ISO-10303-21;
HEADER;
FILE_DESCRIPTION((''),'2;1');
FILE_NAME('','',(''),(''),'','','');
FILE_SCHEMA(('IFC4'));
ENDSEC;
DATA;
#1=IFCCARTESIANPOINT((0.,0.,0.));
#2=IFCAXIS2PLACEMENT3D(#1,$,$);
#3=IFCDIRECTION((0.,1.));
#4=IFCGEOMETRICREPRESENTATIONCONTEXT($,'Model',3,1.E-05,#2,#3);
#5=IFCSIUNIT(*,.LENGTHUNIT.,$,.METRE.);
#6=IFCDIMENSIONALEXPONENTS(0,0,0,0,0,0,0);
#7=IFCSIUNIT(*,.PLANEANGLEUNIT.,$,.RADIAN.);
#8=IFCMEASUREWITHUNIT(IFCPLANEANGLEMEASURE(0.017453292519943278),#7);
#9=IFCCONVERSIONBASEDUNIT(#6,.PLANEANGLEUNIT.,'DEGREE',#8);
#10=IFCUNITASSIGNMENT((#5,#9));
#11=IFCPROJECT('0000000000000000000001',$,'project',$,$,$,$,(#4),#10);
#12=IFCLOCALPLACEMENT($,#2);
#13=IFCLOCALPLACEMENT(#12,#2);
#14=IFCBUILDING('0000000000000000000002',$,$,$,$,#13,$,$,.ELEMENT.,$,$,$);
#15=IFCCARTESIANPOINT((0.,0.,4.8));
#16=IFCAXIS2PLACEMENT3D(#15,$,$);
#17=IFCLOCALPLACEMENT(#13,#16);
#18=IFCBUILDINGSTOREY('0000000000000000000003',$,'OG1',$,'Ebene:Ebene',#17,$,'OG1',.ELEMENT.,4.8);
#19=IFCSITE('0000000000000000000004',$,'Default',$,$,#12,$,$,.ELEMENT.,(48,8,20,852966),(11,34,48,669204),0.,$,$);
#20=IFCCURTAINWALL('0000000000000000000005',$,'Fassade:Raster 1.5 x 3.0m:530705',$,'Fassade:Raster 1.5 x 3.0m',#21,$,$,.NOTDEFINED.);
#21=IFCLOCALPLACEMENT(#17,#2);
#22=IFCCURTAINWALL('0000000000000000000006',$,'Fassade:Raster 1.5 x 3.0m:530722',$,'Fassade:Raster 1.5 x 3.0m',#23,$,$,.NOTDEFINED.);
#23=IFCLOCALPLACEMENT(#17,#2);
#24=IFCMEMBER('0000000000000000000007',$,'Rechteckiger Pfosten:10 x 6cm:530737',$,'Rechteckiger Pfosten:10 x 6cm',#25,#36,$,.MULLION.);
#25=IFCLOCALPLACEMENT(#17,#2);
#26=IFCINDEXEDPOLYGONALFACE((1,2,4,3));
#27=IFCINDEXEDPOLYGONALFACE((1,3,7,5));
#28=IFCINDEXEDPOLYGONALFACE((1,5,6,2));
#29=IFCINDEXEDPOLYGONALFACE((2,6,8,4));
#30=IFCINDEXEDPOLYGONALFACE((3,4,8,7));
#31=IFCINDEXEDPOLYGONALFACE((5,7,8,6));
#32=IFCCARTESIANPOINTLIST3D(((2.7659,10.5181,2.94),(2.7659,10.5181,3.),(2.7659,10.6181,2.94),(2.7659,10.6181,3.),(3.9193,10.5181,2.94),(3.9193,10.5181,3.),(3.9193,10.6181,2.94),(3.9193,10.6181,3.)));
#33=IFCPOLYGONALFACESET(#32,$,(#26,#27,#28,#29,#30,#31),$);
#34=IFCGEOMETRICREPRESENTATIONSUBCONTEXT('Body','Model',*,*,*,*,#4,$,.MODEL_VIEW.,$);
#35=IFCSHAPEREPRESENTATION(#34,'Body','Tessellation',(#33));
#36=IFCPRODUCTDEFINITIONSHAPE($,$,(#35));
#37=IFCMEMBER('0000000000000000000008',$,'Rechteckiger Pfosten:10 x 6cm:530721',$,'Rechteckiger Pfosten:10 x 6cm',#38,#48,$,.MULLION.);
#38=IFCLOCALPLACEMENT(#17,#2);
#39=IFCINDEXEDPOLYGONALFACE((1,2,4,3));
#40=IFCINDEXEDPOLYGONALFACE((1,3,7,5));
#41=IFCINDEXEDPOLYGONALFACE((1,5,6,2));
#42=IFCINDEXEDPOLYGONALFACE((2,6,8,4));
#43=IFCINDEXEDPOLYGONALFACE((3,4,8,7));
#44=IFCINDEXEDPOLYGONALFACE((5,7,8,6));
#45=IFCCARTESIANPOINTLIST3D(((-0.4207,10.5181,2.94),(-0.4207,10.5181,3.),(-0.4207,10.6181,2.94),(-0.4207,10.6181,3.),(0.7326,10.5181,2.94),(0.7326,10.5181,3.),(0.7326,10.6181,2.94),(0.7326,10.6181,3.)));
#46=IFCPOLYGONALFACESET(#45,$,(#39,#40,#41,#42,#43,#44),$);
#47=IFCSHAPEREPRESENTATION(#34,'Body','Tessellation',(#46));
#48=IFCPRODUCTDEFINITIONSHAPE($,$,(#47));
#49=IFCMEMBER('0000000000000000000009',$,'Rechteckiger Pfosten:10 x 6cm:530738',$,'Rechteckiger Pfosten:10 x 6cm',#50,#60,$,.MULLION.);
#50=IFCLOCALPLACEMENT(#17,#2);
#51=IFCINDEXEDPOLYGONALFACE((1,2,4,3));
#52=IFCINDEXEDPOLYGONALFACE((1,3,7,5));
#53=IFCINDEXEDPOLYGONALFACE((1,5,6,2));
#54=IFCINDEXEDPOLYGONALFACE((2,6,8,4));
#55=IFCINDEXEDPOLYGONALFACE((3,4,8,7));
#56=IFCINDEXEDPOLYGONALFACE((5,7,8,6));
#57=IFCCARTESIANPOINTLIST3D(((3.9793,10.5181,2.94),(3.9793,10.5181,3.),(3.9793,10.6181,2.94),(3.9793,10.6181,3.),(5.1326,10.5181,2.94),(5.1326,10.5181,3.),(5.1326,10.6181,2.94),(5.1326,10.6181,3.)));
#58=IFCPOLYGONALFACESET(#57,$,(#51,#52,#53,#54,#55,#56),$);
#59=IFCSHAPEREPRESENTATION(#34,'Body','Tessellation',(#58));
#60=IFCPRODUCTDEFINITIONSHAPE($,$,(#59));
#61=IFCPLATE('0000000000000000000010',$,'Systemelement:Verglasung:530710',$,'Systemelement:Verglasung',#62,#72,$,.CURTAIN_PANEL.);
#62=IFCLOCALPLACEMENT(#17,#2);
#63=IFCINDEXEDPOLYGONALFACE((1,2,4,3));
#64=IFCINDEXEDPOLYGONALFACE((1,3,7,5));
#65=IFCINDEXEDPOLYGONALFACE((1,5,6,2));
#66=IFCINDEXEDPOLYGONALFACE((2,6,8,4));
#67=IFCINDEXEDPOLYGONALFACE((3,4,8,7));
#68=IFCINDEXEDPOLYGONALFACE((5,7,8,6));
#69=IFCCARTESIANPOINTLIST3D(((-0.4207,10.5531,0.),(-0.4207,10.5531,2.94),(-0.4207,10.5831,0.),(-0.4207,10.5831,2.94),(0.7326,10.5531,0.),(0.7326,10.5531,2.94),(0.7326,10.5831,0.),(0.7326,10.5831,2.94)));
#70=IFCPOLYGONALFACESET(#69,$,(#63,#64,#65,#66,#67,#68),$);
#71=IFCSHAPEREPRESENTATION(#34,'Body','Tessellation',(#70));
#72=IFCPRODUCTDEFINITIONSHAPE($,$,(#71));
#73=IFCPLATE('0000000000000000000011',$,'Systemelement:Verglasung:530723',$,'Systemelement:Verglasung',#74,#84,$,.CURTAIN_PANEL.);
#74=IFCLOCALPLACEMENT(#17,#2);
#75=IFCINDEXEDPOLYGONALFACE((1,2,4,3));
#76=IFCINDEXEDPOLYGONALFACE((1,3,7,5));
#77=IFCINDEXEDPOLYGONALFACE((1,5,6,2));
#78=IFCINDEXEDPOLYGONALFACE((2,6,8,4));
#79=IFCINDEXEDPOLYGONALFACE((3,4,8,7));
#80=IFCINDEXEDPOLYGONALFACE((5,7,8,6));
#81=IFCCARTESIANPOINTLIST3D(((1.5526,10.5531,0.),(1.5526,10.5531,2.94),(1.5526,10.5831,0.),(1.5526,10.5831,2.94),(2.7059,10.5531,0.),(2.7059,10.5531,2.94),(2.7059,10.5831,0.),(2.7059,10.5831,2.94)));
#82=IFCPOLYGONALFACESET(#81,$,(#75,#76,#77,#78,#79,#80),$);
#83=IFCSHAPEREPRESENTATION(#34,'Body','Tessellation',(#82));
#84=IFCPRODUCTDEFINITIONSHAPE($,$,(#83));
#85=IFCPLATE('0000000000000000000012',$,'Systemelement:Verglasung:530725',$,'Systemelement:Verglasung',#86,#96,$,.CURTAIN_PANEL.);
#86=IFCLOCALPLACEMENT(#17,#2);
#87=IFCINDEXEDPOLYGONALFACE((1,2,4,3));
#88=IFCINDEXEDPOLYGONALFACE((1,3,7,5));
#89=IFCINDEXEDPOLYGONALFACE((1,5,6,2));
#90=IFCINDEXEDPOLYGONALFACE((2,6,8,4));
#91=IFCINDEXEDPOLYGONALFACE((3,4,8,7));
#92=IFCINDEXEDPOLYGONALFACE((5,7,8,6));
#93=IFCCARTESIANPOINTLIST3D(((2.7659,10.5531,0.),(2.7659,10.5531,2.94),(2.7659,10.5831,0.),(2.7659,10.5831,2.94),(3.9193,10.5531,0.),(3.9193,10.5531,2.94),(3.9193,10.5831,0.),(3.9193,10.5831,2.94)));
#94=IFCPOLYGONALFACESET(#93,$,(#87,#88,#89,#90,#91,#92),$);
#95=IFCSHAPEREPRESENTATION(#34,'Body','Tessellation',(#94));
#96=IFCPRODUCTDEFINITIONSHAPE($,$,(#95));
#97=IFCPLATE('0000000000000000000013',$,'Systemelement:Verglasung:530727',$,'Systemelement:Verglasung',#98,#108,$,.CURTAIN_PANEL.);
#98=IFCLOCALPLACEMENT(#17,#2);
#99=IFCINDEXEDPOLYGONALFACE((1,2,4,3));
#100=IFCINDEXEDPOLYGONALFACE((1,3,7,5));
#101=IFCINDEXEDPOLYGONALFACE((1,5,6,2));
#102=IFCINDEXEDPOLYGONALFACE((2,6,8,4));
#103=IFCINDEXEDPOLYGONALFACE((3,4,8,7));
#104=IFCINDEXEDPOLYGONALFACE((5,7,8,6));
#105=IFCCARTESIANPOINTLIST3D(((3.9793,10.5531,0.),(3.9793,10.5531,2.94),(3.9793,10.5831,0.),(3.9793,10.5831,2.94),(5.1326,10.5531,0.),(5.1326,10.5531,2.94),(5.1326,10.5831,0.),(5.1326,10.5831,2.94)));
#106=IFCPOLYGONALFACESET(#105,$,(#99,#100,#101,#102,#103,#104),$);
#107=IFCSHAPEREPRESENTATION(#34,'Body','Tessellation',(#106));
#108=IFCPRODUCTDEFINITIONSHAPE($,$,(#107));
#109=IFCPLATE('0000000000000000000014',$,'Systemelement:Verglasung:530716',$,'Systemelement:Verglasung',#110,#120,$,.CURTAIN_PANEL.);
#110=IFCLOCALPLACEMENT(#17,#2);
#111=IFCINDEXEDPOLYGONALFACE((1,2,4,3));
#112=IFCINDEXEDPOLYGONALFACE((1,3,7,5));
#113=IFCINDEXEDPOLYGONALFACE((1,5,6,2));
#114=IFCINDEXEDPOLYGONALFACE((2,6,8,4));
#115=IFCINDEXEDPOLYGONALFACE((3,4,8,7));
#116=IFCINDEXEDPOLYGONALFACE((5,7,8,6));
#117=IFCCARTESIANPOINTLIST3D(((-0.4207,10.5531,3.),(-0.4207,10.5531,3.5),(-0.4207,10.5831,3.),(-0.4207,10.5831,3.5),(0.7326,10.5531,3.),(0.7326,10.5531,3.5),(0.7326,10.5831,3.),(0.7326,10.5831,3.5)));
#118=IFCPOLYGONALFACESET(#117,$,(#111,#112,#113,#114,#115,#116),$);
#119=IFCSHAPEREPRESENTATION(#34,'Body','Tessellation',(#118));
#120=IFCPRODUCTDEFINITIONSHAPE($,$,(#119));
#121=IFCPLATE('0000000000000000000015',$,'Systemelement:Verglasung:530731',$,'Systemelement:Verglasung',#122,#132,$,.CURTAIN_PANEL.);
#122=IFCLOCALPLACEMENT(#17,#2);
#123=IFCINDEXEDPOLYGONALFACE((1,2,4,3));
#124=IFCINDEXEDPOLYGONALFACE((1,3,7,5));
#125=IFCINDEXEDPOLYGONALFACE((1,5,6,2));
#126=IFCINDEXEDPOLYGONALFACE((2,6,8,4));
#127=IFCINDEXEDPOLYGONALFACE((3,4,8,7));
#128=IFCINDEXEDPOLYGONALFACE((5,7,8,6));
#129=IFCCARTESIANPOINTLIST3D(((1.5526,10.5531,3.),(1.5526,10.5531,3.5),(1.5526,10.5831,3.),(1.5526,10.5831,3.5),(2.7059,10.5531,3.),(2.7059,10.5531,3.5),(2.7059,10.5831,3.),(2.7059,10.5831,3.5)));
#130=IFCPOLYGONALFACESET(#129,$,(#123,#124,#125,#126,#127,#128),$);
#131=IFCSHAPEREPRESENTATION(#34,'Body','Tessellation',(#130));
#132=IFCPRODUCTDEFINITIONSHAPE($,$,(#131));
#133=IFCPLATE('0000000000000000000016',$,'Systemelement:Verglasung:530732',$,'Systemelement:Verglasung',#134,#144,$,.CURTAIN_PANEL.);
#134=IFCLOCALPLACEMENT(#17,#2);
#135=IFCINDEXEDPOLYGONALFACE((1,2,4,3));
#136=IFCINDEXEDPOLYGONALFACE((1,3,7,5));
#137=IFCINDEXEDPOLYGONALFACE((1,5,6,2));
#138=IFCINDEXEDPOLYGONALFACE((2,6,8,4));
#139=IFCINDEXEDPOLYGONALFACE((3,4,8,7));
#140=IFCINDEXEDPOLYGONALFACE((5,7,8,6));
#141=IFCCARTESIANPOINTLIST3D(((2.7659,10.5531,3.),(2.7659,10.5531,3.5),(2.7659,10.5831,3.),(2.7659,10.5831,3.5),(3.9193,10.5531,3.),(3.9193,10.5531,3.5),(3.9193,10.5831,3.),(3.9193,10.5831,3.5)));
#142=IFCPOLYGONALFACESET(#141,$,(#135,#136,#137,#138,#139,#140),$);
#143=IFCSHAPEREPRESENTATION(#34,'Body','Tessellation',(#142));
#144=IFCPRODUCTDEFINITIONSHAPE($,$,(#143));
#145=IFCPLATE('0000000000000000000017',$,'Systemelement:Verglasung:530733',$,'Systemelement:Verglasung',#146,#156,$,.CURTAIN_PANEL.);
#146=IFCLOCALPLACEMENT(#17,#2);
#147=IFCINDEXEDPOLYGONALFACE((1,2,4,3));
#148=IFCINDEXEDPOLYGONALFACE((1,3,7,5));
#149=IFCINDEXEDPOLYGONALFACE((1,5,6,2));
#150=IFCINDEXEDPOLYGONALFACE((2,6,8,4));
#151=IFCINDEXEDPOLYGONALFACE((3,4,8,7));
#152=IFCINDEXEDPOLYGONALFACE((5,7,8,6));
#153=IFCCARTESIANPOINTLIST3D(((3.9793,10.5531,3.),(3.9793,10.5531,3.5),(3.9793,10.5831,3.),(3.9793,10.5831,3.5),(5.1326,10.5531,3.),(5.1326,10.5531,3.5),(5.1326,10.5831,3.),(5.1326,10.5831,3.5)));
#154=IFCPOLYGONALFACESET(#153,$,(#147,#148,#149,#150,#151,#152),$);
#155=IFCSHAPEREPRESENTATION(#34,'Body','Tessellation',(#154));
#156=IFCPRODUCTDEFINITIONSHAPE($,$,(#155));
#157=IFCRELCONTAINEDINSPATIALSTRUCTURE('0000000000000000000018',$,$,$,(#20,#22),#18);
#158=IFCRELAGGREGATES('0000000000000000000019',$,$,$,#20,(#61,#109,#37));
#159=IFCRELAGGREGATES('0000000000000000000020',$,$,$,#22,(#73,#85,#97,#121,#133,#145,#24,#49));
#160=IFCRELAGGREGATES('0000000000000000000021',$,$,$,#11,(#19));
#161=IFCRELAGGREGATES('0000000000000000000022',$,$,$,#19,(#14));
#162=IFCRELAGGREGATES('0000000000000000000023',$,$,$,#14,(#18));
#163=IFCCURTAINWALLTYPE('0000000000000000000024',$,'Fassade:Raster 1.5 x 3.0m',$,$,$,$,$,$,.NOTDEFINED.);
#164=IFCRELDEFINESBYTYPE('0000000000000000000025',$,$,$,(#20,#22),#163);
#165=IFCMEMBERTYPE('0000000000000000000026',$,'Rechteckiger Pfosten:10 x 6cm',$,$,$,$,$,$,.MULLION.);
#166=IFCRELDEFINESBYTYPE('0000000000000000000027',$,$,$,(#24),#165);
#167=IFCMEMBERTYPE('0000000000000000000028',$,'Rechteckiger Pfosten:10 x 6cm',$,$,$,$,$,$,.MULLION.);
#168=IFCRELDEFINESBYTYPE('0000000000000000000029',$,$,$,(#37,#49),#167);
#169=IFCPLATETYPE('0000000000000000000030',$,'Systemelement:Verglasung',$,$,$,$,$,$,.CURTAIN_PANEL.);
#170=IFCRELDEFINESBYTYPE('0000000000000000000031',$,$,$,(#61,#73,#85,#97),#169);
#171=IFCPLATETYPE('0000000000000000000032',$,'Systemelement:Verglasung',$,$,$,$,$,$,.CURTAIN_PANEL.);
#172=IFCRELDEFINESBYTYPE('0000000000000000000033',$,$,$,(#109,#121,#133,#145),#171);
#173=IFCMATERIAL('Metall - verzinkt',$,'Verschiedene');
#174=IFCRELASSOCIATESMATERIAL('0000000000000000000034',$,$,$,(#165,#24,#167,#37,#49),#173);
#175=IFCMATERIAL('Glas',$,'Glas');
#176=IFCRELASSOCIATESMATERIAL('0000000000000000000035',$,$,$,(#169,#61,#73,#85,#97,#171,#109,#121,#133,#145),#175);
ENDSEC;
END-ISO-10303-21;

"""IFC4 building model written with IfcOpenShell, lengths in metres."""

from ifc_helpers import new_model, entity, si_unit, converted_unit, direction, frame, origin, place, context, subcontext, project, spatial, indexed_curve, outline, extrude, source, transform, mapped, material, type_object, type_shapes, element, aggregate, save


model = new_model("IFC4")

# Units and contexts
model_context = context("Model", 3, precision=1e-05, world=origin(), true_north=direction((0.0, 1.0)))
body_context = subcontext(model_context, "Body", "Model", "MODEL_VIEW")
ifc_project = project(units=[si_unit("LENGTHUNIT", "METRE"), converted_unit("PLANEANGLEUNIT", "DEGREE", entity("IfcPlaneAngleMeasure", 0.017453292519943278), si_unit("PLANEANGLEUNIT", "RADIAN"), dimensions=[0, 0, 0, 0, 0, 0, 0])], contexts=[model_context])

# Site, building, storey
site_placement = place(None, origin())
site = spatial("IfcSite", under=ifc_project, at=site_placement, Name="Default", CompositionType="ELEMENT", RefLatitude=(48, 8, 20, 852966), RefLongitude=(11, 34, 48, 669204), RefElevation=0.0)
building_placement = place(site_placement, origin())
building = spatial("IfcBuilding", under=site, at=building_placement, CompositionType="ELEMENT")
storey_placement = place(building_placement, frame((0.0, 0.0, 4.8)))
storey = spatial("IfcBuildingStorey", under=building, at=storey_placement, Name="OG1", ObjectType="Ebene:Ebene", LongName="OG1", CompositionType="ELEMENT", Elevation=4.8)

# Curtain wall
curtain_wall_type = type_object("IfcCurtainWallType", Name="Fassade:Raster 1.5 x 3.0m", PredefinedType="NOTDEFINED")
curtain_wall_1_placement = place(storey_placement, frame((0.0, 0.0, -4.8)))
curtain_wall_1 = element("IfcCurtainWall", 1, at=curtain_wall_1_placement, inside=storey, type_object=curtain_wall_type, Name="Fassade:Raster 1.5 x 3.0m:530705", ObjectType="Fassade:Raster 1.5 x 3.0m", PredefinedType="NOTDEFINED")
ifc_material_1 = material(Name="Metall - verzinkt", Category="Verschiedene")

# Curtain wall
curtain_wall_2_placement = place(storey_placement, frame((0.0, 0.0, -4.8)))
curtain_wall_2 = element("IfcCurtainWall", 2, at=curtain_wall_2_placement, inside=storey, type_object=curtain_wall_type, Name="Fassade:Raster 1.5 x 3.0m:530722", ObjectType="Fassade:Raster 1.5 x 3.0m", PredefinedType="NOTDEFINED")

# Members
member_type_1 = type_object("IfcMemberType", Name="Rechteckiger Pfosten:10 x 6cm", PredefinedType="MULLION", material=ifc_material_1)
shared_shape_1 = source(origin(), body_context, "Body", "SweptSolid", [
    extrude(outline(indexed_curve([(-0.03, -0.05), (0.03, -0.05), (0.03, 0.05), (-0.03, 0.05), (-0.03, -0.05)], self_intersect=False)), frame((0.0, 0.0, -1.1533), z_axis=(0.0, 0.0, 1.0), x_axis=(-1.0, 0.0, 0.0)), (0.0, 0.0, 1.0), 1.1533),
])
type_shapes(member_type_1, [shared_shape_1])
member_1_placement = place(curtain_wall_2_placement, frame((3.9193, 10.5681, 7.77), z_axis=(1.0, 0.0, 0.0), x_axis=(0.0, 0.0, 1.0)))
member_1 = element("IfcMember", 3, at=member_1_placement, type_object=member_type_1, material=ifc_material_1, Name="Rechteckiger Pfosten:10 x 6cm:530737", ObjectType="Rechteckiger Pfosten:10 x 6cm", PredefinedType="MULLION", context=body_context, shape_type="MappedRepresentation", body=[
    mapped(shared_shape_1, transform((0.0, 0.0, 0.0), scale=1.0)),
])
member_type_2 = type_object("IfcMemberType", Name="Rechteckiger Pfosten:10 x 6cm", PredefinedType="MULLION", material=ifc_material_1)
shared_shape_2 = source(origin(), body_context, "Body", "SweptSolid", [
    extrude(outline(indexed_curve([(-0.03, -0.05), (0.03, -0.05), (0.03, 0.05), (-0.03, 0.05), (-0.03, -0.05)], self_intersect=False)), frame((0.0, 0.0, -1.1533), z_axis=(0.0, 0.0, 1.0), x_axis=(-1.0, 0.0, 0.0)), (0.0, 0.0, 1.0), 1.1533),
])
type_shapes(member_type_2, [shared_shape_2])
member_2_placement = place(curtain_wall_1_placement, frame((0.7326, 10.5681, 7.77), z_axis=(1.0, 0.0, 0.0), x_axis=(0.0, 0.0, 1.0)))
member_2 = element("IfcMember", 4, at=member_2_placement, type_object=member_type_2, material=ifc_material_1, Name="Rechteckiger Pfosten:10 x 6cm:530721", ObjectType="Rechteckiger Pfosten:10 x 6cm", PredefinedType="MULLION", context=body_context, shape_type="MappedRepresentation", body=[
    mapped(shared_shape_2, transform((0.0, 0.0, 0.0), scale=1.0)),
])
member_3_placement = place(curtain_wall_2_placement, frame((5.1326, 10.5681, 7.77), z_axis=(1.0, 0.0, 0.0), x_axis=(0.0, 0.0, 1.0)))
member_3 = element("IfcMember", 5, at=member_3_placement, type_object=member_type_2, material=ifc_material_1, Name="Rechteckiger Pfosten:10 x 6cm:530738", ObjectType="Rechteckiger Pfosten:10 x 6cm", PredefinedType="MULLION", context=body_context, shape_type="MappedRepresentation", body=[
    mapped(shared_shape_2, transform((0.0, 0.0, 0.0), scale=1.0)),
])

# Plates
ifc_material_2 = material(Name="Glas", Category="Glas")
plate_type_1 = type_object("IfcPlateType", Name="Systemelement:Verglasung", PredefinedType="CURTAIN_PANEL", material=ifc_material_2)
shared_shape_3 = source(origin(), body_context, "Body", "SweptSolid", [
    extrude(outline(indexed_curve([(-0.015, -0.5767), (0.015, -0.5767), (0.015, 0.5767), (-0.015, 0.5767), (-0.015, -0.5767)], self_intersect=False)), frame((0.0, 0.0, 0.0), z_axis=(0.0, 0.0, 1.0), x_axis=(0.0, 1.0, 0.0)), (0.0, 0.0, 1.0), 2.94),
])
type_shapes(plate_type_1, [shared_shape_3])
plate_1_placement = place(curtain_wall_1_placement, frame((0.1559, 10.5681, 4.8)))
plate_1 = element("IfcPlate", 6, at=plate_1_placement, type_object=plate_type_1, material=ifc_material_2, Name="Systemelement:Verglasung:530710", ObjectType="Systemelement:Verglasung", PredefinedType="CURTAIN_PANEL", context=body_context, shape_type="MappedRepresentation", body=[
    mapped(shared_shape_3, transform((0.0, 0.0, 0.0), scale=1.0)),
])
plate_2_placement = place(curtain_wall_2_placement, frame((2.1293, 10.5681, 4.8)))
plate_2 = element("IfcPlate", 7, at=plate_2_placement, type_object=plate_type_1, material=ifc_material_2, Name="Systemelement:Verglasung:530723", ObjectType="Systemelement:Verglasung", PredefinedType="CURTAIN_PANEL", context=body_context, shape_type="MappedRepresentation", body=[
    mapped(shared_shape_3, transform((0.0, 0.0, 0.0), scale=1.0)),
])
plate_3_placement = place(curtain_wall_2_placement, frame((3.3426, 10.5681, 4.8)))
plate_3 = element("IfcPlate", 8, at=plate_3_placement, type_object=plate_type_1, material=ifc_material_2, Name="Systemelement:Verglasung:530725", ObjectType="Systemelement:Verglasung", PredefinedType="CURTAIN_PANEL", context=body_context, shape_type="MappedRepresentation", body=[
    mapped(shared_shape_3, transform((0.0, 0.0, 0.0), scale=1.0)),
])
plate_4_placement = place(curtain_wall_2_placement, frame((4.5559, 10.5681, 4.8)))
plate_4 = element("IfcPlate", 9, at=plate_4_placement, type_object=plate_type_1, material=ifc_material_2, Name="Systemelement:Verglasung:530727", ObjectType="Systemelement:Verglasung", PredefinedType="CURTAIN_PANEL", context=body_context, shape_type="MappedRepresentation", body=[
    mapped(shared_shape_3, transform((0.0, 0.0, 0.0), scale=1.0)),
])
plate_type_2 = type_object("IfcPlateType", Name="Systemelement:Verglasung", PredefinedType="CURTAIN_PANEL", material=ifc_material_2)
shared_shape_4 = source(origin(), body_context, "Body", "SweptSolid", [
    extrude(outline(indexed_curve([(-0.015, -0.5767), (0.015, -0.5767), (0.015, 0.5767), (-0.015, 0.5767), (-0.015, -0.5767)], self_intersect=False)), frame((0.0, 0.0, 0.0), z_axis=(0.0, 0.0, 1.0), x_axis=(0.0, 1.0, 0.0)), (0.0, 0.0, 1.0), 0.5),
])
type_shapes(plate_type_2, [shared_shape_4])
plate_5_placement = place(curtain_wall_1_placement, frame((0.1559, 10.5681, 7.8)))
plate_5 = element("IfcPlate", 10, at=plate_5_placement, type_object=plate_type_2, material=ifc_material_2, Name="Systemelement:Verglasung:530716", ObjectType="Systemelement:Verglasung", PredefinedType="CURTAIN_PANEL", context=body_context, shape_type="MappedRepresentation", body=[
    mapped(shared_shape_4, transform((0.0, 0.0, 0.0), scale=1.0)),
])
aggregate(curtain_wall_1, [plate_1, plate_5, member_2])
plate_6_placement = place(curtain_wall_2_placement, frame((2.1293, 10.5681, 7.8)))
plate_6 = element("IfcPlate", 11, at=plate_6_placement, type_object=plate_type_2, material=ifc_material_2, Name="Systemelement:Verglasung:530731", ObjectType="Systemelement:Verglasung", PredefinedType="CURTAIN_PANEL", context=body_context, shape_type="MappedRepresentation", body=[
    mapped(shared_shape_4, transform((0.0, 0.0, 0.0), scale=1.0)),
])
plate_7_placement = place(curtain_wall_2_placement, frame((3.3426, 10.5681, 7.8)))
plate_7 = element("IfcPlate", 12, at=plate_7_placement, type_object=plate_type_2, material=ifc_material_2, Name="Systemelement:Verglasung:530732", ObjectType="Systemelement:Verglasung", PredefinedType="CURTAIN_PANEL", context=body_context, shape_type="MappedRepresentation", body=[
    mapped(shared_shape_4, transform((0.0, 0.0, 0.0), scale=1.0)),
])
plate_8_placement = place(curtain_wall_2_placement, frame((4.5559, 10.5681, 7.8)))
plate_8 = element("IfcPlate", 13, at=plate_8_placement, type_object=plate_type_2, material=ifc_material_2, Name="Systemelement:Verglasung:530733", ObjectType="Systemelement:Verglasung", PredefinedType="CURTAIN_PANEL", context=body_context, shape_type="MappedRepresentation", body=[
    mapped(shared_shape_4, transform((0.0, 0.0, 0.0), scale=1.0)),
])
aggregate(curtain_wall_2, [plate_2, plate_3, plate_4, plate_6, plate_7, plate_8, member_1, member_3])

save(model, "model.ifc")
